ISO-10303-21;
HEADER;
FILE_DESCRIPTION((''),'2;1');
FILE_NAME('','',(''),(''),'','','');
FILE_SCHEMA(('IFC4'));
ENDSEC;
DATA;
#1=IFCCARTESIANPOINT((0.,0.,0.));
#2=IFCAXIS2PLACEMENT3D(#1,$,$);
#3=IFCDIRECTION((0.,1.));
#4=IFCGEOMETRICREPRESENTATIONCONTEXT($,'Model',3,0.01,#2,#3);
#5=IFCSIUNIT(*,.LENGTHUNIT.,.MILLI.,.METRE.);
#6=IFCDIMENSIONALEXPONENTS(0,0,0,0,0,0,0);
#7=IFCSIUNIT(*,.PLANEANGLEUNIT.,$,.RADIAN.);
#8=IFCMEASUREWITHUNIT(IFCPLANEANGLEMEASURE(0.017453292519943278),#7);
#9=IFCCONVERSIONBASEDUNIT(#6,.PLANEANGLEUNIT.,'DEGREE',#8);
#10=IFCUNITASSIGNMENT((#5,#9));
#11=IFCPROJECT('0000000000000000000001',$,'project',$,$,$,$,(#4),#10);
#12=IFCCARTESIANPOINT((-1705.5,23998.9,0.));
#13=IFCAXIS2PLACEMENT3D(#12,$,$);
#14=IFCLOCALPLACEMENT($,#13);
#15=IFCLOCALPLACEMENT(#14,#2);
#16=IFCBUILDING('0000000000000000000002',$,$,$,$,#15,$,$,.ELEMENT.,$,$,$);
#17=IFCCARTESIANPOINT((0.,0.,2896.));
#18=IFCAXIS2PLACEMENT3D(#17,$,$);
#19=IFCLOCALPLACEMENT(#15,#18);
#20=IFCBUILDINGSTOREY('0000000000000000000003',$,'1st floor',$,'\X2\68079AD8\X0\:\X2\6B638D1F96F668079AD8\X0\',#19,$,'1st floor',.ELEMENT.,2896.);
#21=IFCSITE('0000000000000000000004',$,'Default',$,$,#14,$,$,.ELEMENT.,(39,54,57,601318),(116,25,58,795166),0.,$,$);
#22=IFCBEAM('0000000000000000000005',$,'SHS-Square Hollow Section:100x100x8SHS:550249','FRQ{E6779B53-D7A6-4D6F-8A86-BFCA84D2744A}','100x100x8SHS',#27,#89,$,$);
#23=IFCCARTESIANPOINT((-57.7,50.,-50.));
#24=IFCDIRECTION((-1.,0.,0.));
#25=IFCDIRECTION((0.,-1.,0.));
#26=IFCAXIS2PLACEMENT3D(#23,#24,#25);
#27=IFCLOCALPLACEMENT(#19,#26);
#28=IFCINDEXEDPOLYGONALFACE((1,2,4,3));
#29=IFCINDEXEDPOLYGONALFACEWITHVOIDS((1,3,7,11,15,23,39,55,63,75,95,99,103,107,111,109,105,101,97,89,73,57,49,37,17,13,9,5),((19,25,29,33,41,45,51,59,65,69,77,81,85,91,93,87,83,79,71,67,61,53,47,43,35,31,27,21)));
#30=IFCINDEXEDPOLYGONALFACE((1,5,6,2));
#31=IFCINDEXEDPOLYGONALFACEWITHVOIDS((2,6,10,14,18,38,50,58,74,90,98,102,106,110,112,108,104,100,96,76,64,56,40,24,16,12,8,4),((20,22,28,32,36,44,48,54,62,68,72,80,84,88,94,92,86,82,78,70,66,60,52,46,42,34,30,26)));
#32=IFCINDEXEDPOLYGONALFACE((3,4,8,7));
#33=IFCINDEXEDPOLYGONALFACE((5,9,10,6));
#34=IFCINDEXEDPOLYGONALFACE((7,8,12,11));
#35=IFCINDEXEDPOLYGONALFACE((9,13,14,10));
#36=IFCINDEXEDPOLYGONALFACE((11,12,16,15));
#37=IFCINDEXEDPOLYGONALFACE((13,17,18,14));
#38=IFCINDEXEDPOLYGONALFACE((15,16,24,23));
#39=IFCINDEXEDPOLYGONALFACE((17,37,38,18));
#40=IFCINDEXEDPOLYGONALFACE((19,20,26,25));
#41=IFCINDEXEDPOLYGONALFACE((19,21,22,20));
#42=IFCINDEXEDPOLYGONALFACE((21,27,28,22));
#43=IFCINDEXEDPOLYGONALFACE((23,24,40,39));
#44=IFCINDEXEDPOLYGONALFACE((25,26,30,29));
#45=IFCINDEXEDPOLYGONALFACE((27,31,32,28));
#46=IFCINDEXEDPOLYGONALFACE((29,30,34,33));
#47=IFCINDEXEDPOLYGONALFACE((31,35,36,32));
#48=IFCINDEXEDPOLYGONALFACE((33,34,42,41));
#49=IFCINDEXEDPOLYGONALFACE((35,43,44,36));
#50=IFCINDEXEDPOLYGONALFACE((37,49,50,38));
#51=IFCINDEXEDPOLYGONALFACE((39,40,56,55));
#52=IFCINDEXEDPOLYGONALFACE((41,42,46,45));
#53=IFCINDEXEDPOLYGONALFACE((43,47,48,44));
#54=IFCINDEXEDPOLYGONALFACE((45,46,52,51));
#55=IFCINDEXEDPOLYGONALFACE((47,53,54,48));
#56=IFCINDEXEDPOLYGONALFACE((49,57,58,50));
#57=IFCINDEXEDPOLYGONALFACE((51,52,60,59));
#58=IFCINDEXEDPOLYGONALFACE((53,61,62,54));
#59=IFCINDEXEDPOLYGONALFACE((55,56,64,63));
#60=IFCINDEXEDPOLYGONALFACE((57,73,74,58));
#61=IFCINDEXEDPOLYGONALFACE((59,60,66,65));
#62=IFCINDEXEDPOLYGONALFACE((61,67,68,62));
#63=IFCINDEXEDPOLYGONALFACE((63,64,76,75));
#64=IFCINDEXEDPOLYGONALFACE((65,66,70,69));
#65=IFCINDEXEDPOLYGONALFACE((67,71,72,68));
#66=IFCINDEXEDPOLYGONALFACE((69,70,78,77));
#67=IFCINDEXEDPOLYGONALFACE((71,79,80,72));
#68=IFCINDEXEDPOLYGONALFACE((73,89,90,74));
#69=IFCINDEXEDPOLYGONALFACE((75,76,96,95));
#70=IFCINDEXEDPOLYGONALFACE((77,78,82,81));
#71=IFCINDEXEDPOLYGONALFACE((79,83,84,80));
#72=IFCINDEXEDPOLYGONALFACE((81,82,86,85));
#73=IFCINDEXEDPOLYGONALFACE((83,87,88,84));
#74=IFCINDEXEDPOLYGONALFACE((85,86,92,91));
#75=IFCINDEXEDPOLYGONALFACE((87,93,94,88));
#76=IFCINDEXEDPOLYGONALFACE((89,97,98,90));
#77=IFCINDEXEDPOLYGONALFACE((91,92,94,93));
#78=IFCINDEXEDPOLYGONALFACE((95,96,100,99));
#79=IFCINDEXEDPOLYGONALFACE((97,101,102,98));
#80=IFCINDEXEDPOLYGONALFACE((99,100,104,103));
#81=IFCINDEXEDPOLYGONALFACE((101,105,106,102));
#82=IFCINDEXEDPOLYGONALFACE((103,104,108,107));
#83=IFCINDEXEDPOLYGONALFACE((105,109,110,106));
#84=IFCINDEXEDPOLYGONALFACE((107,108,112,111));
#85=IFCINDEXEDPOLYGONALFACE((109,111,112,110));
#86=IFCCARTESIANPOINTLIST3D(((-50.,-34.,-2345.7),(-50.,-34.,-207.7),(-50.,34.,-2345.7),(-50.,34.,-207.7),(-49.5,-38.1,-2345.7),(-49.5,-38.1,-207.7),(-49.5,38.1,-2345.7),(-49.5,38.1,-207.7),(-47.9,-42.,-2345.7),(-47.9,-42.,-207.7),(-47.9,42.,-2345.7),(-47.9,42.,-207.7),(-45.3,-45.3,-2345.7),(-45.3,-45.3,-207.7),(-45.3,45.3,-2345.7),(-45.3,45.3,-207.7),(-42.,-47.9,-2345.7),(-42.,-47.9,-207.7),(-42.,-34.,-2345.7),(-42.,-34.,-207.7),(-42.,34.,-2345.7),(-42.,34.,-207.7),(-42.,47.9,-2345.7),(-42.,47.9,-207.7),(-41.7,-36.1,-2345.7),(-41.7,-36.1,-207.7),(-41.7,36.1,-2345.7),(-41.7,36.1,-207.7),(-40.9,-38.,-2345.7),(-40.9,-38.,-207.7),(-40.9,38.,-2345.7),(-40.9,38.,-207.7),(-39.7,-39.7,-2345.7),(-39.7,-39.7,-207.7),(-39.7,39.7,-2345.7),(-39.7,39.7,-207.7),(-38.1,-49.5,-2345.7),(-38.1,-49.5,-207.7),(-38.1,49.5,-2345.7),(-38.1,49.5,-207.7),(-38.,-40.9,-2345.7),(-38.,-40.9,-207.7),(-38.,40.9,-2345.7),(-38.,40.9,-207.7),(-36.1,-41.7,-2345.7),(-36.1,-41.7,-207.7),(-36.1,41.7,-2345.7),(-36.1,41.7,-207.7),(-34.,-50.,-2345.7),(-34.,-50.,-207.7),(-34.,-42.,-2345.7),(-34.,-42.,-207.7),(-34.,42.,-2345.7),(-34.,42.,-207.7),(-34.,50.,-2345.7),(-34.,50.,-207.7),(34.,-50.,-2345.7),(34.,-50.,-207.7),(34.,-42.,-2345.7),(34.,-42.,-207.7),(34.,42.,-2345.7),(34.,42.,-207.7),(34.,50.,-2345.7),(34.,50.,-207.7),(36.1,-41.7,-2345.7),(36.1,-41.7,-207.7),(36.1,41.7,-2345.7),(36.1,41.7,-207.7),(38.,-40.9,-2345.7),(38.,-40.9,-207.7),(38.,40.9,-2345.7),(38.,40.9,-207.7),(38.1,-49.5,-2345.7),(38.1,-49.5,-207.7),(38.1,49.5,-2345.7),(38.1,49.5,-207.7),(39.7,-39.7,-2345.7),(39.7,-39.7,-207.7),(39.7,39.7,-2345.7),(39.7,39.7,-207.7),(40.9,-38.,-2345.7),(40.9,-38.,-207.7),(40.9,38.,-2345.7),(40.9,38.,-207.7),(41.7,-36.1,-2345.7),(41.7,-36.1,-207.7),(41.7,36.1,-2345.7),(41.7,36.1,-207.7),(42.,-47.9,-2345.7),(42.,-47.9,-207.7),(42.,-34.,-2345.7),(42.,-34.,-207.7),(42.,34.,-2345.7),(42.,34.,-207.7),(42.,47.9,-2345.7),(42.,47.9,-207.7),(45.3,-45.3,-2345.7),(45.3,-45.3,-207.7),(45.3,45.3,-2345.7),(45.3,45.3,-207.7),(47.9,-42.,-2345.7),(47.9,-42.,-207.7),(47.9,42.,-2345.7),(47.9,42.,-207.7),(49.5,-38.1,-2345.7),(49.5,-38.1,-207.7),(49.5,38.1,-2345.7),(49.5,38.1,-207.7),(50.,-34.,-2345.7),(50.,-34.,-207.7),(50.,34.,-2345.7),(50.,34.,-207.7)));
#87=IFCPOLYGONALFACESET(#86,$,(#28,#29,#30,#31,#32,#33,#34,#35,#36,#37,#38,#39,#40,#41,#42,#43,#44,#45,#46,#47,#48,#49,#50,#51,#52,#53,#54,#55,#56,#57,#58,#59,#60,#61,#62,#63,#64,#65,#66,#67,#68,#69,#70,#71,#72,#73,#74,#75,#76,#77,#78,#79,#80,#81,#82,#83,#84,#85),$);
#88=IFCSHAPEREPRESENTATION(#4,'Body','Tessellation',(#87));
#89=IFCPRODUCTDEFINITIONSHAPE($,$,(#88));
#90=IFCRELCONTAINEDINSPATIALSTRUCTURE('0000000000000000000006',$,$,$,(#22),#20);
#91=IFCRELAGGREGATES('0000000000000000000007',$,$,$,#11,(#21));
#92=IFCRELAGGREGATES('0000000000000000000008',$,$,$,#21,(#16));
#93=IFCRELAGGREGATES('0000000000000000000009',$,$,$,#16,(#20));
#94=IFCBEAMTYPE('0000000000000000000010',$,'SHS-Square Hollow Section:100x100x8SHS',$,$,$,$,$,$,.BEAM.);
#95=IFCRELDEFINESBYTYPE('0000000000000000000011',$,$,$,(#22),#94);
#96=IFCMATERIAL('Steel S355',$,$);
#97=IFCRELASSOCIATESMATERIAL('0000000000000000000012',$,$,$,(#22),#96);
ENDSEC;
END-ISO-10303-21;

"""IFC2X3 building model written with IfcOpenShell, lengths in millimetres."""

from ifc_helpers import new_model, entity, si_unit, converted_unit, direction, frame, origin, origin_2d, place, context, project, spatial, hollow_rectangle, extrude, clip, halfspace, material, type_object, element, save


model = new_model("IFC2X3")

# Units and contexts
model_context = context("Model", 3, precision=0.01, world=origin(), true_north=direction((0.0, 1.0)))
ifc_project = project(units=[si_unit("LENGTHUNIT", "METRE", prefix="MILLI"), converted_unit("PLANEANGLEUNIT", "DEGREE", entity("IfcPlaneAngleMeasure", 0.017453292519943278), si_unit("PLANEANGLEUNIT", "RADIAN"), dimensions=[0, 0, 0, 0, 0, 0, 0])], contexts=[model_context])

# Site, building, storey
site_placement = place(None, frame((-1705.5, 23998.9, 0.0)))
site = spatial("IfcSite", under=ifc_project, at=site_placement, Name="Default", CompositionType="ELEMENT", RefLatitude=(39, 54, 57, 601318), RefLongitude=(116, 25, 58, 795166), RefElevation=0.0)
building_placement = place(site_placement, origin())
building = spatial("IfcBuilding", under=site, at=building_placement, CompositionType="ELEMENT")
storey_placement = place(building_placement, frame((0.0, 0.0, 2896.0)))
storey = spatial("IfcBuildingStorey", under=building, at=storey_placement, Name="1st floor", ObjectType="标高:正负零标高", LongName="1st floor", CompositionType="ELEMENT", Elevation=2896.0)

# Shared definitions
ifc_material_1 = material(Name="Steel S355")

# Beam
beam_type_1 = type_object("IfcBeamType", Name="SHS-Square Hollow Section:100x100x8SHS", PredefinedType="BEAM")
beam_1_placement = place(storey_placement, frame((-57.7, 50.0, -50.0), z_axis=(-1.0, 0.0, 0.0), x_axis=(0.0, -1.0, 0.0)))
element("IfcBeam", 1, at=beam_1_placement, inside=storey, type_object=beam_type_1, material=ifc_material_1, Name="SHS-Square Hollow Section:100x100x8SHS:550249", Description="FRQ{E6779B53-D7A6-4D6F-8A86-BFCA84D2744A}", ObjectType="100x100x8SHS", context=model_context, shape_type="Clipping", body=[
    clip(clip(extrude(hollow_rectangle(XDim=100.0, YDim=100.0, WallThickness=8.0, InnerFilletRadius=8.0, OuterFilletRadius=16.0, at=origin_2d()), origin(), (0.0, 0.0, -1.0), 2551.4), halfspace(frame((50.0, -2846.0, -207.7), z_axis=(0.0, 0.0, -1.0), x_axis=(-1.0, 0.0, 0.0)), True)), halfspace(frame((50.0, -2846.0, -2345.7), z_axis=(0.0, 0.0, 1.0), x_axis=(1.0, 0.0, 0.0)), True)),
])

save(model, "model.ifc")
